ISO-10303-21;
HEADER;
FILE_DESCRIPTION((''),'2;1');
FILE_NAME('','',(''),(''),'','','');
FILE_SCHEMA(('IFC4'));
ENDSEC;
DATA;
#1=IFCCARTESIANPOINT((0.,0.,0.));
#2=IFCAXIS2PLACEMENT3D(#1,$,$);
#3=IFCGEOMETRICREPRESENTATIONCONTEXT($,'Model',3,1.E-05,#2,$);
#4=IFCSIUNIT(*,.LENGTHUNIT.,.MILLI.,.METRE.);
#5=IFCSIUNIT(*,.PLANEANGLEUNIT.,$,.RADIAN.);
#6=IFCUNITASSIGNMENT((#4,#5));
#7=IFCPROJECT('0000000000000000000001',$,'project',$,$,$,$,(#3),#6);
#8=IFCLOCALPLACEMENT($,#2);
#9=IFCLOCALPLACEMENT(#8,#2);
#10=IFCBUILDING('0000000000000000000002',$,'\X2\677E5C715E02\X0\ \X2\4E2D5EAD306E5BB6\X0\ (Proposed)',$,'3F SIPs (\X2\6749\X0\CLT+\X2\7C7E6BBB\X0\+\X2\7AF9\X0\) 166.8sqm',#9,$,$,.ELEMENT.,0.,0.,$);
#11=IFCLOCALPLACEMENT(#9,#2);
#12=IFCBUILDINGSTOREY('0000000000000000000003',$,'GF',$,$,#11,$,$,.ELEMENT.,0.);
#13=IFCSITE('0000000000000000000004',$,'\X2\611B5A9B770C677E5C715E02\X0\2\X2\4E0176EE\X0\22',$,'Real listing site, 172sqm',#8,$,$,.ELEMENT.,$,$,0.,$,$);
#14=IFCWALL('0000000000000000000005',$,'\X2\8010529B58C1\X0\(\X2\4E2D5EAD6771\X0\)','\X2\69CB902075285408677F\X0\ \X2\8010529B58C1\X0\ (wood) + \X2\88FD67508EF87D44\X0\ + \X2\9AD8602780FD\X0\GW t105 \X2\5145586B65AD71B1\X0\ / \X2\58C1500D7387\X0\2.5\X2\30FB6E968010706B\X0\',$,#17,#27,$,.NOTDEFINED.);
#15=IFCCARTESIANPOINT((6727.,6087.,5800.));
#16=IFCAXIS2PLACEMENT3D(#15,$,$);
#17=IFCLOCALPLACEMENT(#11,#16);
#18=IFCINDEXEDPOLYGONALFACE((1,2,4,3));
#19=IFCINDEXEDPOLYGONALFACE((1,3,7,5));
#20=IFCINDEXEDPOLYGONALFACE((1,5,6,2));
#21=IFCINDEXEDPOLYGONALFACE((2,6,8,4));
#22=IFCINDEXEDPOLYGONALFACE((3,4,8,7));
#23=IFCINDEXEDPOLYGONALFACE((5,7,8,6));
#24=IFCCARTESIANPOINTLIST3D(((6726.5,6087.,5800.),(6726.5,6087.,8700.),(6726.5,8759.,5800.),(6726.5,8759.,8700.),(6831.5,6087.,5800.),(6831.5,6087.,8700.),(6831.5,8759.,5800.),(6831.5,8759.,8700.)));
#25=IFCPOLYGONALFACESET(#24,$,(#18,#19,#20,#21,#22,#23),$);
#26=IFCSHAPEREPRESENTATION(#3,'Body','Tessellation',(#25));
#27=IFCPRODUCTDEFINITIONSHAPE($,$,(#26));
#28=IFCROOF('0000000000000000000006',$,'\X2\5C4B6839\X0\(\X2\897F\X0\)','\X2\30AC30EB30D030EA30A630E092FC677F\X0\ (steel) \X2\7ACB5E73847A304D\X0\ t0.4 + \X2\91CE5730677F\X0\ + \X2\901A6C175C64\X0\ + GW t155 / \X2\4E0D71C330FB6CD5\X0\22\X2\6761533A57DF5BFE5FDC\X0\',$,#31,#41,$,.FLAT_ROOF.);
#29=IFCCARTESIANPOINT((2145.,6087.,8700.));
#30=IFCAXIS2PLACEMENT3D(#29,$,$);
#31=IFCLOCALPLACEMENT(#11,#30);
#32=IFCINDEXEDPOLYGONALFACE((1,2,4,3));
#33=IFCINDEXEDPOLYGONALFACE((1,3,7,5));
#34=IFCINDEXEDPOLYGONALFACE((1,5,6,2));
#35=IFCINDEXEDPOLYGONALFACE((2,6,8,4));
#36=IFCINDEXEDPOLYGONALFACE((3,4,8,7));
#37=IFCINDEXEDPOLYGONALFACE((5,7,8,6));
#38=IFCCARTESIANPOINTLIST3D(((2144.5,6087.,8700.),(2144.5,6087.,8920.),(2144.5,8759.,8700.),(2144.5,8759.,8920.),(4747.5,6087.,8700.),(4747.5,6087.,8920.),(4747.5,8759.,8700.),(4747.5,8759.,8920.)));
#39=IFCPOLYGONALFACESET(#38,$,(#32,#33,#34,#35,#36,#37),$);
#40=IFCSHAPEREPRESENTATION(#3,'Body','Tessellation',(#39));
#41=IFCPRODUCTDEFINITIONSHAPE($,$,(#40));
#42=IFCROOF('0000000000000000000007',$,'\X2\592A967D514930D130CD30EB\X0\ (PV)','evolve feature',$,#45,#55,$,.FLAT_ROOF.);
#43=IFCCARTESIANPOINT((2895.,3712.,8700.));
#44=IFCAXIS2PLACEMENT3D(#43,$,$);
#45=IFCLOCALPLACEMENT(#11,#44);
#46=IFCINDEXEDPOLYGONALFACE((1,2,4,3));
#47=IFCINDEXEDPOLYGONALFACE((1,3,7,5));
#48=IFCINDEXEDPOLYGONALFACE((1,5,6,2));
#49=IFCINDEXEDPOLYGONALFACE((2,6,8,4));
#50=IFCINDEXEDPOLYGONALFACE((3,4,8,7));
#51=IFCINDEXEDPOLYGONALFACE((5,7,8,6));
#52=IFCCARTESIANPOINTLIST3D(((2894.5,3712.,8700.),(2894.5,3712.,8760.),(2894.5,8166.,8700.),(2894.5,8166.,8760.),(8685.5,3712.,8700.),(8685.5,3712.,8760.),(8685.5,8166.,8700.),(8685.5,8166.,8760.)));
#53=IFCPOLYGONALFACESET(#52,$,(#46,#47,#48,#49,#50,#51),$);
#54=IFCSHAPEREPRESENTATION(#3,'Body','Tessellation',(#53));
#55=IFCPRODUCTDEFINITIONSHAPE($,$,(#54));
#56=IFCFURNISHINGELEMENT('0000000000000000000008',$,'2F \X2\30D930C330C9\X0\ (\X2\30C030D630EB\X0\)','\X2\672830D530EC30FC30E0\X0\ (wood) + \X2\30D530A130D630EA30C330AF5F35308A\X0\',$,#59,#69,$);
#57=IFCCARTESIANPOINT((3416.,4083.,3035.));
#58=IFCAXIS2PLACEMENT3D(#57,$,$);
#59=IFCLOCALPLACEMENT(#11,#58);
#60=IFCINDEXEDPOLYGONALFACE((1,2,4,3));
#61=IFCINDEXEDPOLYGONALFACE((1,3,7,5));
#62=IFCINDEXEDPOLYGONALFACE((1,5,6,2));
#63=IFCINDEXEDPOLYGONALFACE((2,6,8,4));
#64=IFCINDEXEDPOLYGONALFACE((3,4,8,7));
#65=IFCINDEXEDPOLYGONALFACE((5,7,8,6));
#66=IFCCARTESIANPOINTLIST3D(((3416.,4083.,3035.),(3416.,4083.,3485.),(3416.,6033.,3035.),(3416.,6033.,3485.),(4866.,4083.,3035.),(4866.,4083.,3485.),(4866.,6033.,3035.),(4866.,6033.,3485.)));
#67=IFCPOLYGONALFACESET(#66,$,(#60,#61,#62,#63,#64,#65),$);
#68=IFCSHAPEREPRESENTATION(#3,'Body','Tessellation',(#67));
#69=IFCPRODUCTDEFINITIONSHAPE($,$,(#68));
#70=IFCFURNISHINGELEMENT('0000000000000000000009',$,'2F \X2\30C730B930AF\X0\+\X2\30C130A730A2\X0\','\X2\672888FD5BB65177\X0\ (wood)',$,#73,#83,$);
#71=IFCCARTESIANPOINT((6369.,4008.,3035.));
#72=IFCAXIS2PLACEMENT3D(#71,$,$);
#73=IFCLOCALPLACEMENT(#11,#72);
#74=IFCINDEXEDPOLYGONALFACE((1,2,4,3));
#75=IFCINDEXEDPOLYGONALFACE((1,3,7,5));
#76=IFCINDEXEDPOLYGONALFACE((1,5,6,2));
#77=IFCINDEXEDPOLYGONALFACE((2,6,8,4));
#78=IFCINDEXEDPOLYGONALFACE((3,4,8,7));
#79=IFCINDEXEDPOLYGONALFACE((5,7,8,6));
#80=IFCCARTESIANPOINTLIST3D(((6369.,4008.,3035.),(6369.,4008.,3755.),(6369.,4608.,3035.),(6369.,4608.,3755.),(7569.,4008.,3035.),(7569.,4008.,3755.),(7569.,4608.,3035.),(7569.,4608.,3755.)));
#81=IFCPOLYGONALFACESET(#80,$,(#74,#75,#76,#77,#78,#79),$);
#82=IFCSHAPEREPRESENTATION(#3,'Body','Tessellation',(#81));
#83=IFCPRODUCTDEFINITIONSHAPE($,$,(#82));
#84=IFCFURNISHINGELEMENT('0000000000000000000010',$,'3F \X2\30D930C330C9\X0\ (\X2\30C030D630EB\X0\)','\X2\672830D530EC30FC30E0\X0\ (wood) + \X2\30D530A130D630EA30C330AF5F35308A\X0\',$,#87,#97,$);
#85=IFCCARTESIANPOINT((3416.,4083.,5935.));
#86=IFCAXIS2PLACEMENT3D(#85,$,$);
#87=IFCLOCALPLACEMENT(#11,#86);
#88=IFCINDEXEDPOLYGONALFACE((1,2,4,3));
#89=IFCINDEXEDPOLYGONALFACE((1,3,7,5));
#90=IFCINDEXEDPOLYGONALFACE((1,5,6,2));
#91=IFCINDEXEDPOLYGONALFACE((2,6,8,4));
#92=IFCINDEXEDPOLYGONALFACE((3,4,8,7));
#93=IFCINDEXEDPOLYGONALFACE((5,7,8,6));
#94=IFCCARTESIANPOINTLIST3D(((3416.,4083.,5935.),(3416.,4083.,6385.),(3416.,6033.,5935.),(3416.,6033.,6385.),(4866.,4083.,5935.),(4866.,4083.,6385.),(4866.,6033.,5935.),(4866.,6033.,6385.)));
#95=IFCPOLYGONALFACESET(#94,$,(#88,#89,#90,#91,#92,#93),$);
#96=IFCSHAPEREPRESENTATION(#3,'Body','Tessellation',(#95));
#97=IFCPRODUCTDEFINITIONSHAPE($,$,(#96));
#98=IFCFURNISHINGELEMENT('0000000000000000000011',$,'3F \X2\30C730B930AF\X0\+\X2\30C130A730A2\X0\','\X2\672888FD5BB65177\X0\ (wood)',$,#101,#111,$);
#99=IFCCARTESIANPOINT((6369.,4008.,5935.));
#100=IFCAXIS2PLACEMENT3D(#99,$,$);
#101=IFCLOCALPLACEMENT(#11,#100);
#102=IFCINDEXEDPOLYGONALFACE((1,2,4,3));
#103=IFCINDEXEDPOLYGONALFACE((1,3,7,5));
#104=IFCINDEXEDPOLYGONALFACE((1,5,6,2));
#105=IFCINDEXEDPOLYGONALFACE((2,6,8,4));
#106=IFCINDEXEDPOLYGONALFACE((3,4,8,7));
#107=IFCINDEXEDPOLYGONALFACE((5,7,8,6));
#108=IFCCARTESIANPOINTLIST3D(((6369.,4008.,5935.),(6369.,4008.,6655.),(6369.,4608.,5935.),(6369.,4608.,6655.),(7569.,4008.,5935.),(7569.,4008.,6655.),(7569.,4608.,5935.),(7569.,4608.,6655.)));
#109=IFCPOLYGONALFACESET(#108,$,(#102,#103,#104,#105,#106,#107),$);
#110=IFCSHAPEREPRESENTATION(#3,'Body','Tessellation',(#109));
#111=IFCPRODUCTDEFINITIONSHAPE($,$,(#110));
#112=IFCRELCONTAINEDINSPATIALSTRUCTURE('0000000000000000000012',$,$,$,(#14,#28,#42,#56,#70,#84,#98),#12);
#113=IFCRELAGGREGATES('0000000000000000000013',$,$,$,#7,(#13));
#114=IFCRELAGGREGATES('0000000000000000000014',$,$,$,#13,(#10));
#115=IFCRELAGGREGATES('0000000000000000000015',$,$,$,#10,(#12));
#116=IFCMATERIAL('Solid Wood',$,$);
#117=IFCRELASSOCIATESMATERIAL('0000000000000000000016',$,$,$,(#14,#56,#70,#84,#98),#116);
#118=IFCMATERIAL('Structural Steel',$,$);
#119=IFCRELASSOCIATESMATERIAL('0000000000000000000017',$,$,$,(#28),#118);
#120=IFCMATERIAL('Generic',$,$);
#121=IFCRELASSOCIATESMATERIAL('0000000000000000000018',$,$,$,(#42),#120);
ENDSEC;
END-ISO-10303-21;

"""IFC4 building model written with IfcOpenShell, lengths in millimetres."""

from ifc_helpers import new_model, si_unit, frame, frame_2d, origin, place, context, project, spatial, rectangle, extrude, material, element, save


model = new_model("IFC4")

# Units and contexts
model_context = context("Model", 3, precision=1e-05, world=origin())
ifc_project = project(units=[si_unit("LENGTHUNIT", "METRE", prefix="MILLI"), si_unit("PLANEANGLEUNIT", "RADIAN")], contexts=[model_context])

# Site, building, storey
site_placement = place(None, origin())
site = spatial("IfcSite", under=ifc_project, at=site_placement, Name="愛媛県松山市2丁目22", ObjectType="Real listing site, 172sqm", CompositionType="ELEMENT", RefElevation=0.0)
building_placement = place(site_placement, origin())
building = spatial("IfcBuilding", under=site, at=building_placement, Name="松山市 中庭の家 (Proposed)", ObjectType="3F SIPs (杉CLT+籾殻+竹) 166.8sqm", CompositionType="ELEMENT", ElevationOfRefHeight=0.0, ElevationOfTerrain=0.0)
storey_placement = place(building_placement, origin())
storey = spatial("IfcBuildingStorey", under=building, at=storey_placement, Name="GF", CompositionType="ELEMENT", Elevation=0.0)

# Shared definitions
ifc_material_1 = material(Name="Solid Wood")

# Wall
wall_1_placement = place(storey_placement, frame((6727.0, 6087.0, 5800.0)))
element("IfcWall", 1, at=wall_1_placement, inside=storey, material=ifc_material_1, Name="耐力壁(中庭東)", Description="構造用合板 耐力壁 (wood) + 製材軸組 + 高性能GW t105 充填断熱 / 壁倍率2.5・準耐火", PredefinedType="NOTDEFINED", context=model_context, shape_type="SweptSolid", body=[
    extrude(rectangle(XDim=105.0, YDim=2672.0, at=frame_2d((52.0, 1336.0))), frame((6727.0, 6087.0, 5800.0)), (0.0, 0.0, 1.0), 2900.0),
])

# Roofs
ifc_material_2 = material(Name="Structural Steel")
roof_1_placement = place(storey_placement, frame((2145.0, 6087.0, 8700.0)))
element("IfcRoof", 2, at=roof_1_placement, inside=storey, material=ifc_material_2, Name="屋根(西)", Description="ガルバリウム鋼板 (steel) 立平葺き t0.4 + 野地板 + 通気層 + GW t155 / 不燃・法22条区域対応", PredefinedType="FLAT_ROOF", context=model_context, shape_type="SweptSolid", body=[
    extrude(rectangle(XDim=2603.0, YDim=2672.0, at=frame_2d((1301.0, 1336.0))), frame((2145.0, 6087.0, 8700.0)), (0.0, 0.0, 1.0), 220.0),
])
ifc_material_3 = material(Name="Generic")
roof_2_placement = place(storey_placement, frame((2895.0, 3712.0, 8700.0)))
element("IfcRoof", 3, at=roof_2_placement, inside=storey, material=ifc_material_3, Name="太陽光パネル (PV)", Description="evolve feature", PredefinedType="FLAT_ROOF", context=model_context, shape_type="SweptSolid", body=[
    extrude(rectangle(XDim=5791.0, YDim=4454.0, at=frame_2d((2895.0, 2227.0))), frame((2895.0, 3712.0, 8700.0)), (0.0, 0.0, 1.0), 60.0),
])

# Furnishing elements
furnishing_1_placement = place(storey_placement, frame((3416.0, 4083.0, 3035.0)))
element("IfcFurnishingElement", 4, at=furnishing_1_placement, inside=storey, material=ifc_material_1, Name="2F ベッド (ダブル)", Description="木フレーム (wood) + ファブリック張り", context=model_context, shape_type="SweptSolid", body=[
    extrude(rectangle(XDim=1450.0, YDim=1950.0, at=frame_2d((725.0, 975.0))), frame((3416.0, 4083.0, 3035.0)), (0.0, 0.0, 1.0), 450.0),
])
furnishing_2_placement = place(storey_placement, frame((6369.0, 4008.0, 3035.0)))
element("IfcFurnishingElement", 5, at=furnishing_2_placement, inside=storey, material=ifc_material_1, Name="2F デスク+チェア", Description="木製家具 (wood)", context=model_context, shape_type="SweptSolid", body=[
    extrude(rectangle(XDim=1200.0, YDim=600.0, at=frame_2d((600.0, 300.0))), frame((6369.0, 4008.0, 3035.0)), (0.0, 0.0, 1.0), 720.0),
])
furnishing_3_placement = place(storey_placement, frame((3416.0, 4083.0, 5935.0)))
element("IfcFurnishingElement", 6, at=furnishing_3_placement, inside=storey, material=ifc_material_1, Name="3F ベッド (ダブル)", Description="木フレーム (wood) + ファブリック張り", context=model_context, shape_type="SweptSolid", body=[
    extrude(rectangle(XDim=1450.0, YDim=1950.0, at=frame_2d((725.0, 975.0))), frame((3416.0, 4083.0, 5935.0)), (0.0, 0.0, 1.0), 450.0),
])
furnishing_4_placement = place(storey_placement, frame((6369.0, 4008.0, 5935.0)))
element("IfcFurnishingElement", 7, at=furnishing_4_placement, inside=storey, material=ifc_material_1, Name="3F デスク+チェア", Description="木製家具 (wood)", context=model_context, shape_type="SweptSolid", body=[
    extrude(rectangle(XDim=1200.0, YDim=600.0, at=frame_2d((600.0, 300.0))), frame((6369.0, 4008.0, 5935.0)), (0.0, 0.0, 1.0), 720.0),
])

save(model, "model.ifc")
